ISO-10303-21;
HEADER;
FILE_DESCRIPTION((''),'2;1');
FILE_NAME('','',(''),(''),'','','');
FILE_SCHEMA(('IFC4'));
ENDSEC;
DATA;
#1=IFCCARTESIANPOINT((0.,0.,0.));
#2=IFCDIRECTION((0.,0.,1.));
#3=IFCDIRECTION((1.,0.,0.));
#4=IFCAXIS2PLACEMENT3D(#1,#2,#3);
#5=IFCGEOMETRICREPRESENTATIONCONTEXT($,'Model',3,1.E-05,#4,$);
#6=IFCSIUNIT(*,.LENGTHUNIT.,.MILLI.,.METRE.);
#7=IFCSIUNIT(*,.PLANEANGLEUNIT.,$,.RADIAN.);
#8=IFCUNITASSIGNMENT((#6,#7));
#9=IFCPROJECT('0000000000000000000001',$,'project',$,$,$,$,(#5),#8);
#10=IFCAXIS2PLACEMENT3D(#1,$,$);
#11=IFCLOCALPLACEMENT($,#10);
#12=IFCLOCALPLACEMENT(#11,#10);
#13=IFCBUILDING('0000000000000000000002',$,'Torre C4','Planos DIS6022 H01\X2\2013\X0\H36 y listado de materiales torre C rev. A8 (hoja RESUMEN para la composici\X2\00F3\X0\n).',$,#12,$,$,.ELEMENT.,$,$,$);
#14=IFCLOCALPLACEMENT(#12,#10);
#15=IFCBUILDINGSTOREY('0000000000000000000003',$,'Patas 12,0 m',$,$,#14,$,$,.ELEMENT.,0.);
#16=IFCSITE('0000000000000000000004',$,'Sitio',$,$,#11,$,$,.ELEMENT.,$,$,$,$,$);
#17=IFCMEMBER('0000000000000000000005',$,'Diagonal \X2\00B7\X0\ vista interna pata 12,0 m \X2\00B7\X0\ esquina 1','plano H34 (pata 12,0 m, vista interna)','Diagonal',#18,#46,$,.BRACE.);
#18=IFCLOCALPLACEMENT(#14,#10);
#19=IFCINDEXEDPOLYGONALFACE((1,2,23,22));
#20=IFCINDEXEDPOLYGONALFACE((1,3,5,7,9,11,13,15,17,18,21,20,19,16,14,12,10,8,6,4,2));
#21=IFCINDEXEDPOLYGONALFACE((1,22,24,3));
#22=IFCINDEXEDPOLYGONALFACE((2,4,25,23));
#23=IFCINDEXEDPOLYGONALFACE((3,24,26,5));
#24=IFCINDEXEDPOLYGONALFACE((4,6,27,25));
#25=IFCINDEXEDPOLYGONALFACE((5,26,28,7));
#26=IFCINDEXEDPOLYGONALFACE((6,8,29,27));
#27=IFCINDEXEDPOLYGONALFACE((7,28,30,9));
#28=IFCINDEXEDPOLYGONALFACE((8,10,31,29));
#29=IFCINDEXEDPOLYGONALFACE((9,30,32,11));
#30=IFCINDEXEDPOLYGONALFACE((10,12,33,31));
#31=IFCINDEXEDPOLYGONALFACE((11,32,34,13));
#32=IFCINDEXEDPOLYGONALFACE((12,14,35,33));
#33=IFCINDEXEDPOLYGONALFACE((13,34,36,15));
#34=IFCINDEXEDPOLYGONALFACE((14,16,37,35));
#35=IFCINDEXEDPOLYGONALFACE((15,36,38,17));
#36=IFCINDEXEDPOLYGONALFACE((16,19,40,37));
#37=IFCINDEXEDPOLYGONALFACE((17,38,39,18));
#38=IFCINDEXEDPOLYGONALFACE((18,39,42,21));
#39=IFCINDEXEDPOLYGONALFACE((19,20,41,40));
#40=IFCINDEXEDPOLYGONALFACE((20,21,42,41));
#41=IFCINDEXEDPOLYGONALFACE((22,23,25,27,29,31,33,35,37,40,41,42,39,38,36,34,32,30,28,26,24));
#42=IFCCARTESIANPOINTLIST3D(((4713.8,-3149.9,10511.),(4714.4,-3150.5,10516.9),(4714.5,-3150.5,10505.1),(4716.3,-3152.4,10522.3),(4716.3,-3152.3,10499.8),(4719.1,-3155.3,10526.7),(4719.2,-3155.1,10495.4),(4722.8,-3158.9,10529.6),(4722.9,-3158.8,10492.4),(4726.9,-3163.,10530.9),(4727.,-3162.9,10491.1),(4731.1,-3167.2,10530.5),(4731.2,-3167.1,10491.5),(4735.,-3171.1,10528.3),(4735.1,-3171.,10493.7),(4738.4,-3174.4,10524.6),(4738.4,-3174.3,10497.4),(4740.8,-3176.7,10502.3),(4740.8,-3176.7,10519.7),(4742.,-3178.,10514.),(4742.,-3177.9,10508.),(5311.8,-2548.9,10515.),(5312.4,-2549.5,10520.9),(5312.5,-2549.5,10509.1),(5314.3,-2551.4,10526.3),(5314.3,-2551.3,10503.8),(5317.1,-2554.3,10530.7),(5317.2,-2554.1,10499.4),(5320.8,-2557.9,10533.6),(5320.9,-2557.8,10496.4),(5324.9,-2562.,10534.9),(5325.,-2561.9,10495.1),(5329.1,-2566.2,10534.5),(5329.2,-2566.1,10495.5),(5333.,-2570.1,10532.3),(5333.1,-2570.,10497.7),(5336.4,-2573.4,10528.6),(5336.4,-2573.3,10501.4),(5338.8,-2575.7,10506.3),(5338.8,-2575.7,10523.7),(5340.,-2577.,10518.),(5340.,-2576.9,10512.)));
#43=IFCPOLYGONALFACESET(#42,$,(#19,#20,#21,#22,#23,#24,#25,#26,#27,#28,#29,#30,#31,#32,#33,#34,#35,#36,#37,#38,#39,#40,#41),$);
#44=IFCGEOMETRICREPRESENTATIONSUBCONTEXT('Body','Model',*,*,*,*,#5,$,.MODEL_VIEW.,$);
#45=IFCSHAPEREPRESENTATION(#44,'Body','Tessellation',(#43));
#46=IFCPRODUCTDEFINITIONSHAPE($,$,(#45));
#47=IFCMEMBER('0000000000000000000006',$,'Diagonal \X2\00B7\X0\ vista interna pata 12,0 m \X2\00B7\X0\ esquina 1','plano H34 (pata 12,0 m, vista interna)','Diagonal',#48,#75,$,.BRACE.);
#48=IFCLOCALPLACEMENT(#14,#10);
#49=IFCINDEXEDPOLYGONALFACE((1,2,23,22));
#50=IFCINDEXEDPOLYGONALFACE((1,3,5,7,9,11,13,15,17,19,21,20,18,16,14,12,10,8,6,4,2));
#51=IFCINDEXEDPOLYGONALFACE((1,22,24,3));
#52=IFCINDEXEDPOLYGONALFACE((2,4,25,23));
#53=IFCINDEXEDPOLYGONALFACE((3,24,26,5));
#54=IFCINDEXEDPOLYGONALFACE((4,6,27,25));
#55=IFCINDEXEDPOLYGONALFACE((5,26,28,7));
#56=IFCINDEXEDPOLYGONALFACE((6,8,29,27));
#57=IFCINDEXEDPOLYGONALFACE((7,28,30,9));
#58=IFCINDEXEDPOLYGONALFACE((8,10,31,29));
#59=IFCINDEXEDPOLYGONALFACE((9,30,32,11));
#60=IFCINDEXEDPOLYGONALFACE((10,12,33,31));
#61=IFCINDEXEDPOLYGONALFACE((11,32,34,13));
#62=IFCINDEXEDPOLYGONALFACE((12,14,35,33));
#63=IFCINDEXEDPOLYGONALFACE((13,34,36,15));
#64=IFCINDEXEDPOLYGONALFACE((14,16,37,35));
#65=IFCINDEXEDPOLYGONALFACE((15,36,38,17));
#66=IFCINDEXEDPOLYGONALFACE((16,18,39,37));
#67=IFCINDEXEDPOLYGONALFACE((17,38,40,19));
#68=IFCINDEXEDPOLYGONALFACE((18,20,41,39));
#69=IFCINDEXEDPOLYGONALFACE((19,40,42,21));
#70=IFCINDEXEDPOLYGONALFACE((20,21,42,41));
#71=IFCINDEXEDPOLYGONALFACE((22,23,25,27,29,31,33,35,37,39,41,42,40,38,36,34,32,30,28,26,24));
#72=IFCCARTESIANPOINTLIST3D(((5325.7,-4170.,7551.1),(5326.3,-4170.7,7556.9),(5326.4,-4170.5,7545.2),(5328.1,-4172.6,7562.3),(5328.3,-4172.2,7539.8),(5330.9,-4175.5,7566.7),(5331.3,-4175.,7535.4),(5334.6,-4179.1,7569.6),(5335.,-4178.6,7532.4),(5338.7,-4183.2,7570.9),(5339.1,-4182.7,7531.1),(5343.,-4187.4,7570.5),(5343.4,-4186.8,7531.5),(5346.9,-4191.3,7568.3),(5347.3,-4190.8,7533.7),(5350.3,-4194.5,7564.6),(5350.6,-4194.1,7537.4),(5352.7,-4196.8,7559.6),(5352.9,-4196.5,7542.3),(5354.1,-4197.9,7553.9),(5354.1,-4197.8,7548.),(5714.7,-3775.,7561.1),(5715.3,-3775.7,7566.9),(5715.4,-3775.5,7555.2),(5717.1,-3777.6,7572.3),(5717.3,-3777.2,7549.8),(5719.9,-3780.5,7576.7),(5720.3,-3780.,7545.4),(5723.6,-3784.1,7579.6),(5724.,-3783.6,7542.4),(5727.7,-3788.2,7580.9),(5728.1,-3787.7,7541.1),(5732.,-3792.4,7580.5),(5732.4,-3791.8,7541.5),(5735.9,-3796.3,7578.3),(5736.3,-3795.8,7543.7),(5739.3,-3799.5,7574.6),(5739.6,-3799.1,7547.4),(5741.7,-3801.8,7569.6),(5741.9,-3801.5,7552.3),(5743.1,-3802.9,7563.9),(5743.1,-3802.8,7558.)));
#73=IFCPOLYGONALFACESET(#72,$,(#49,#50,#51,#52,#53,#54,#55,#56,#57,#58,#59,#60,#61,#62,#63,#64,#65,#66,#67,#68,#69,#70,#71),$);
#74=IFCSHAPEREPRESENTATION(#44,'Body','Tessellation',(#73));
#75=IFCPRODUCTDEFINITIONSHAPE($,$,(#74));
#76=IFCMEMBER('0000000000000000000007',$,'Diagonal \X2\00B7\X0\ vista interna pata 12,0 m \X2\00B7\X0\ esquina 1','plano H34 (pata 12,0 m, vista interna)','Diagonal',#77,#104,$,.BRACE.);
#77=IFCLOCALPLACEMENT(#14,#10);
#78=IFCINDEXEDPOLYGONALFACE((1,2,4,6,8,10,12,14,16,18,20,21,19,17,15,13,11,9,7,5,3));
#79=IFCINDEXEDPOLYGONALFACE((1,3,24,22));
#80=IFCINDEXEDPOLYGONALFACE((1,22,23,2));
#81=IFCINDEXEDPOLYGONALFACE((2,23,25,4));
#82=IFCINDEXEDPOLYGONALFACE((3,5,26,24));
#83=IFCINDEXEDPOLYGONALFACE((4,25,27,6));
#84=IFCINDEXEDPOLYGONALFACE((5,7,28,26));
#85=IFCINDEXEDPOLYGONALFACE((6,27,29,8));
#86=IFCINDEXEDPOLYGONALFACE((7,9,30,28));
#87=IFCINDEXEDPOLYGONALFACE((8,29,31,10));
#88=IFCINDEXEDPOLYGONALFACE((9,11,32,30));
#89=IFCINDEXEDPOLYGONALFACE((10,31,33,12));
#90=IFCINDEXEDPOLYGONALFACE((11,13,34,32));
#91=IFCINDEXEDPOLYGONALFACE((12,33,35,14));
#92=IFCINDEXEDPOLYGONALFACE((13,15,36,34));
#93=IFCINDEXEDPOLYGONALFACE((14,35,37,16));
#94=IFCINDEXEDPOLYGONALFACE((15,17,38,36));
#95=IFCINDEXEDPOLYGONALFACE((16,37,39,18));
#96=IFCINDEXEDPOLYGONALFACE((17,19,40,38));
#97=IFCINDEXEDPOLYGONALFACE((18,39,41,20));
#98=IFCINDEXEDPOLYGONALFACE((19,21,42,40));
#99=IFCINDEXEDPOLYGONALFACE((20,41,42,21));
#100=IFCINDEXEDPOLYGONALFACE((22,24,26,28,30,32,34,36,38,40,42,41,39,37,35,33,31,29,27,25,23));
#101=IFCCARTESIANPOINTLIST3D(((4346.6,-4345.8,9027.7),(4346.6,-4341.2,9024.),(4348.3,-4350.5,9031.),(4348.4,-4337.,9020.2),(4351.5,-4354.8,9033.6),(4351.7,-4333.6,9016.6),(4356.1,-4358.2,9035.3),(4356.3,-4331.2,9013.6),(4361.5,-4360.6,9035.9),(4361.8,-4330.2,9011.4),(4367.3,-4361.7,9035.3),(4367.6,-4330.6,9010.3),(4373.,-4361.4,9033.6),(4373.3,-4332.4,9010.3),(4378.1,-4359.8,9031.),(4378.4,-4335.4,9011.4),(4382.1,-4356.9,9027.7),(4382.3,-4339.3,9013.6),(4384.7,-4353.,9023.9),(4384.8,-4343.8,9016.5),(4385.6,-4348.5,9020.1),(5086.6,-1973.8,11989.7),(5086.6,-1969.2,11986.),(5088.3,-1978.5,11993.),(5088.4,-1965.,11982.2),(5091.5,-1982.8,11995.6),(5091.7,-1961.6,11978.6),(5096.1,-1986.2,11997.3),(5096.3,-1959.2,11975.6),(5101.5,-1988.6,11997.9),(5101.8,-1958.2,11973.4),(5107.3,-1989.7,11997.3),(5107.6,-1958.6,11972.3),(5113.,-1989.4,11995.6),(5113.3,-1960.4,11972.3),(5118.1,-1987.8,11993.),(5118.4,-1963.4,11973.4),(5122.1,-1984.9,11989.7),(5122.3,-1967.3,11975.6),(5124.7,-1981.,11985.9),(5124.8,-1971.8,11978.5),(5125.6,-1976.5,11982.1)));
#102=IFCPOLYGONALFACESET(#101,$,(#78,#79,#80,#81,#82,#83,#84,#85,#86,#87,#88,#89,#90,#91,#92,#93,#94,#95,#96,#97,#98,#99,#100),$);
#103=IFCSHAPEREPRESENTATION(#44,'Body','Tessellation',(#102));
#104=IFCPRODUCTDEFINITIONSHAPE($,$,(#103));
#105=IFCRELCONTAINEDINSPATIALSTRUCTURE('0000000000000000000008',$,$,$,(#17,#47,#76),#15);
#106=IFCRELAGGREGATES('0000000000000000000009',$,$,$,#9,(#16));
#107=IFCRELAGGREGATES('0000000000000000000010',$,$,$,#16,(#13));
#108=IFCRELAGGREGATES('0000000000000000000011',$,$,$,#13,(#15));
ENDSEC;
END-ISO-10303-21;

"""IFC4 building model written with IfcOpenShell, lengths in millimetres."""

from ifc_helpers import new_model, si_unit, frame, origin, origin_with_axes, place, context, subcontext, project, spatial, circle, extrude, element, save


model = new_model("IFC4")

# Units and contexts
model_context = context("Model", 3, precision=1e-05, world=origin_with_axes())
body_context = subcontext(model_context, "Body", "Model", "MODEL_VIEW")
ifc_project = project(units=[si_unit("LENGTHUNIT", "METRE", prefix="MILLI"), si_unit("PLANEANGLEUNIT", "RADIAN")], contexts=[model_context])

# Site, building, storey
site_placement = place(None, origin())
site = spatial("IfcSite", under=ifc_project, at=site_placement, Name="Sitio", CompositionType="ELEMENT")
building_placement = place(site_placement, origin())
building = spatial("IfcBuilding", under=site, at=building_placement, Name="Torre C4", Description="Planos DIS6022 H01–H36 y listado de materiales torre C rev. A8 (hoja RESUMEN para la composición).", CompositionType="ELEMENT")
storey_placement = place(building_placement, origin())
storey = spatial("IfcBuildingStorey", under=building, at=storey_placement, Name="Patas 12,0 m", CompositionType="ELEMENT", Elevation=0.0)

# Members
member_1_placement = place(storey_placement, frame((4728.0, -3164.0, 10511.0), z_axis=(0.705327, 0.708866, 0.004718), x_axis=(-0.708877, 0.70533, 0.001281)))
element("IfcMember", 1, at=member_1_placement, inside=storey, Name="Diagonal · vista interna pata 12,0 m · esquina 1", Description="plano H34 (pata 12,0 m, vista interna)", ObjectType="Diagonal", PredefinedType="BRACE", context=body_context, shape_type="SweptSolid", body=[
    extrude(circle(Radius=20.0), None, (0.0, 0.0, 1.0), 847.8),
])
member_2_placement = place(storey_placement, frame((5340.0, -4184.0, 7551.0), z_axis=(0.701561, 0.712382, 0.018035), x_axis=(-0.71253, 0.701636, 0.00279)))
element("IfcMember", 2, at=member_2_placement, inside=storey, Name="Diagonal · vista interna pata 12,0 m · esquina 1", Description="plano H34 (pata 12,0 m, vista interna)", ObjectType="Diagonal", PredefinedType="BRACE", context=body_context, shape_type="SweptSolid", body=[
    extrude(circle(Radius=20.0), None, (0.0, 0.0, 1.0), 554.5),
])
member_3_placement = place(storey_placement, frame((4366.0, -4346.0, 9023.0), z_axis=(0.191403, 0.613524, 0.766129), x_axis=(-0.88114, 0.451268, -0.141244)))
element("IfcMember", 3, at=member_3_placement, inside=storey, Name="Diagonal · vista interna pata 12,0 m · esquina 1", Description="plano H34 (pata 12,0 m, vista interna)", ObjectType="Diagonal", PredefinedType="BRACE", context=body_context, shape_type="SweptSolid", body=[
    extrude(circle(Radius=20.0), None, (0.0, 0.0, 1.0), 3866.2),
])

save(model, "model.ifc")
